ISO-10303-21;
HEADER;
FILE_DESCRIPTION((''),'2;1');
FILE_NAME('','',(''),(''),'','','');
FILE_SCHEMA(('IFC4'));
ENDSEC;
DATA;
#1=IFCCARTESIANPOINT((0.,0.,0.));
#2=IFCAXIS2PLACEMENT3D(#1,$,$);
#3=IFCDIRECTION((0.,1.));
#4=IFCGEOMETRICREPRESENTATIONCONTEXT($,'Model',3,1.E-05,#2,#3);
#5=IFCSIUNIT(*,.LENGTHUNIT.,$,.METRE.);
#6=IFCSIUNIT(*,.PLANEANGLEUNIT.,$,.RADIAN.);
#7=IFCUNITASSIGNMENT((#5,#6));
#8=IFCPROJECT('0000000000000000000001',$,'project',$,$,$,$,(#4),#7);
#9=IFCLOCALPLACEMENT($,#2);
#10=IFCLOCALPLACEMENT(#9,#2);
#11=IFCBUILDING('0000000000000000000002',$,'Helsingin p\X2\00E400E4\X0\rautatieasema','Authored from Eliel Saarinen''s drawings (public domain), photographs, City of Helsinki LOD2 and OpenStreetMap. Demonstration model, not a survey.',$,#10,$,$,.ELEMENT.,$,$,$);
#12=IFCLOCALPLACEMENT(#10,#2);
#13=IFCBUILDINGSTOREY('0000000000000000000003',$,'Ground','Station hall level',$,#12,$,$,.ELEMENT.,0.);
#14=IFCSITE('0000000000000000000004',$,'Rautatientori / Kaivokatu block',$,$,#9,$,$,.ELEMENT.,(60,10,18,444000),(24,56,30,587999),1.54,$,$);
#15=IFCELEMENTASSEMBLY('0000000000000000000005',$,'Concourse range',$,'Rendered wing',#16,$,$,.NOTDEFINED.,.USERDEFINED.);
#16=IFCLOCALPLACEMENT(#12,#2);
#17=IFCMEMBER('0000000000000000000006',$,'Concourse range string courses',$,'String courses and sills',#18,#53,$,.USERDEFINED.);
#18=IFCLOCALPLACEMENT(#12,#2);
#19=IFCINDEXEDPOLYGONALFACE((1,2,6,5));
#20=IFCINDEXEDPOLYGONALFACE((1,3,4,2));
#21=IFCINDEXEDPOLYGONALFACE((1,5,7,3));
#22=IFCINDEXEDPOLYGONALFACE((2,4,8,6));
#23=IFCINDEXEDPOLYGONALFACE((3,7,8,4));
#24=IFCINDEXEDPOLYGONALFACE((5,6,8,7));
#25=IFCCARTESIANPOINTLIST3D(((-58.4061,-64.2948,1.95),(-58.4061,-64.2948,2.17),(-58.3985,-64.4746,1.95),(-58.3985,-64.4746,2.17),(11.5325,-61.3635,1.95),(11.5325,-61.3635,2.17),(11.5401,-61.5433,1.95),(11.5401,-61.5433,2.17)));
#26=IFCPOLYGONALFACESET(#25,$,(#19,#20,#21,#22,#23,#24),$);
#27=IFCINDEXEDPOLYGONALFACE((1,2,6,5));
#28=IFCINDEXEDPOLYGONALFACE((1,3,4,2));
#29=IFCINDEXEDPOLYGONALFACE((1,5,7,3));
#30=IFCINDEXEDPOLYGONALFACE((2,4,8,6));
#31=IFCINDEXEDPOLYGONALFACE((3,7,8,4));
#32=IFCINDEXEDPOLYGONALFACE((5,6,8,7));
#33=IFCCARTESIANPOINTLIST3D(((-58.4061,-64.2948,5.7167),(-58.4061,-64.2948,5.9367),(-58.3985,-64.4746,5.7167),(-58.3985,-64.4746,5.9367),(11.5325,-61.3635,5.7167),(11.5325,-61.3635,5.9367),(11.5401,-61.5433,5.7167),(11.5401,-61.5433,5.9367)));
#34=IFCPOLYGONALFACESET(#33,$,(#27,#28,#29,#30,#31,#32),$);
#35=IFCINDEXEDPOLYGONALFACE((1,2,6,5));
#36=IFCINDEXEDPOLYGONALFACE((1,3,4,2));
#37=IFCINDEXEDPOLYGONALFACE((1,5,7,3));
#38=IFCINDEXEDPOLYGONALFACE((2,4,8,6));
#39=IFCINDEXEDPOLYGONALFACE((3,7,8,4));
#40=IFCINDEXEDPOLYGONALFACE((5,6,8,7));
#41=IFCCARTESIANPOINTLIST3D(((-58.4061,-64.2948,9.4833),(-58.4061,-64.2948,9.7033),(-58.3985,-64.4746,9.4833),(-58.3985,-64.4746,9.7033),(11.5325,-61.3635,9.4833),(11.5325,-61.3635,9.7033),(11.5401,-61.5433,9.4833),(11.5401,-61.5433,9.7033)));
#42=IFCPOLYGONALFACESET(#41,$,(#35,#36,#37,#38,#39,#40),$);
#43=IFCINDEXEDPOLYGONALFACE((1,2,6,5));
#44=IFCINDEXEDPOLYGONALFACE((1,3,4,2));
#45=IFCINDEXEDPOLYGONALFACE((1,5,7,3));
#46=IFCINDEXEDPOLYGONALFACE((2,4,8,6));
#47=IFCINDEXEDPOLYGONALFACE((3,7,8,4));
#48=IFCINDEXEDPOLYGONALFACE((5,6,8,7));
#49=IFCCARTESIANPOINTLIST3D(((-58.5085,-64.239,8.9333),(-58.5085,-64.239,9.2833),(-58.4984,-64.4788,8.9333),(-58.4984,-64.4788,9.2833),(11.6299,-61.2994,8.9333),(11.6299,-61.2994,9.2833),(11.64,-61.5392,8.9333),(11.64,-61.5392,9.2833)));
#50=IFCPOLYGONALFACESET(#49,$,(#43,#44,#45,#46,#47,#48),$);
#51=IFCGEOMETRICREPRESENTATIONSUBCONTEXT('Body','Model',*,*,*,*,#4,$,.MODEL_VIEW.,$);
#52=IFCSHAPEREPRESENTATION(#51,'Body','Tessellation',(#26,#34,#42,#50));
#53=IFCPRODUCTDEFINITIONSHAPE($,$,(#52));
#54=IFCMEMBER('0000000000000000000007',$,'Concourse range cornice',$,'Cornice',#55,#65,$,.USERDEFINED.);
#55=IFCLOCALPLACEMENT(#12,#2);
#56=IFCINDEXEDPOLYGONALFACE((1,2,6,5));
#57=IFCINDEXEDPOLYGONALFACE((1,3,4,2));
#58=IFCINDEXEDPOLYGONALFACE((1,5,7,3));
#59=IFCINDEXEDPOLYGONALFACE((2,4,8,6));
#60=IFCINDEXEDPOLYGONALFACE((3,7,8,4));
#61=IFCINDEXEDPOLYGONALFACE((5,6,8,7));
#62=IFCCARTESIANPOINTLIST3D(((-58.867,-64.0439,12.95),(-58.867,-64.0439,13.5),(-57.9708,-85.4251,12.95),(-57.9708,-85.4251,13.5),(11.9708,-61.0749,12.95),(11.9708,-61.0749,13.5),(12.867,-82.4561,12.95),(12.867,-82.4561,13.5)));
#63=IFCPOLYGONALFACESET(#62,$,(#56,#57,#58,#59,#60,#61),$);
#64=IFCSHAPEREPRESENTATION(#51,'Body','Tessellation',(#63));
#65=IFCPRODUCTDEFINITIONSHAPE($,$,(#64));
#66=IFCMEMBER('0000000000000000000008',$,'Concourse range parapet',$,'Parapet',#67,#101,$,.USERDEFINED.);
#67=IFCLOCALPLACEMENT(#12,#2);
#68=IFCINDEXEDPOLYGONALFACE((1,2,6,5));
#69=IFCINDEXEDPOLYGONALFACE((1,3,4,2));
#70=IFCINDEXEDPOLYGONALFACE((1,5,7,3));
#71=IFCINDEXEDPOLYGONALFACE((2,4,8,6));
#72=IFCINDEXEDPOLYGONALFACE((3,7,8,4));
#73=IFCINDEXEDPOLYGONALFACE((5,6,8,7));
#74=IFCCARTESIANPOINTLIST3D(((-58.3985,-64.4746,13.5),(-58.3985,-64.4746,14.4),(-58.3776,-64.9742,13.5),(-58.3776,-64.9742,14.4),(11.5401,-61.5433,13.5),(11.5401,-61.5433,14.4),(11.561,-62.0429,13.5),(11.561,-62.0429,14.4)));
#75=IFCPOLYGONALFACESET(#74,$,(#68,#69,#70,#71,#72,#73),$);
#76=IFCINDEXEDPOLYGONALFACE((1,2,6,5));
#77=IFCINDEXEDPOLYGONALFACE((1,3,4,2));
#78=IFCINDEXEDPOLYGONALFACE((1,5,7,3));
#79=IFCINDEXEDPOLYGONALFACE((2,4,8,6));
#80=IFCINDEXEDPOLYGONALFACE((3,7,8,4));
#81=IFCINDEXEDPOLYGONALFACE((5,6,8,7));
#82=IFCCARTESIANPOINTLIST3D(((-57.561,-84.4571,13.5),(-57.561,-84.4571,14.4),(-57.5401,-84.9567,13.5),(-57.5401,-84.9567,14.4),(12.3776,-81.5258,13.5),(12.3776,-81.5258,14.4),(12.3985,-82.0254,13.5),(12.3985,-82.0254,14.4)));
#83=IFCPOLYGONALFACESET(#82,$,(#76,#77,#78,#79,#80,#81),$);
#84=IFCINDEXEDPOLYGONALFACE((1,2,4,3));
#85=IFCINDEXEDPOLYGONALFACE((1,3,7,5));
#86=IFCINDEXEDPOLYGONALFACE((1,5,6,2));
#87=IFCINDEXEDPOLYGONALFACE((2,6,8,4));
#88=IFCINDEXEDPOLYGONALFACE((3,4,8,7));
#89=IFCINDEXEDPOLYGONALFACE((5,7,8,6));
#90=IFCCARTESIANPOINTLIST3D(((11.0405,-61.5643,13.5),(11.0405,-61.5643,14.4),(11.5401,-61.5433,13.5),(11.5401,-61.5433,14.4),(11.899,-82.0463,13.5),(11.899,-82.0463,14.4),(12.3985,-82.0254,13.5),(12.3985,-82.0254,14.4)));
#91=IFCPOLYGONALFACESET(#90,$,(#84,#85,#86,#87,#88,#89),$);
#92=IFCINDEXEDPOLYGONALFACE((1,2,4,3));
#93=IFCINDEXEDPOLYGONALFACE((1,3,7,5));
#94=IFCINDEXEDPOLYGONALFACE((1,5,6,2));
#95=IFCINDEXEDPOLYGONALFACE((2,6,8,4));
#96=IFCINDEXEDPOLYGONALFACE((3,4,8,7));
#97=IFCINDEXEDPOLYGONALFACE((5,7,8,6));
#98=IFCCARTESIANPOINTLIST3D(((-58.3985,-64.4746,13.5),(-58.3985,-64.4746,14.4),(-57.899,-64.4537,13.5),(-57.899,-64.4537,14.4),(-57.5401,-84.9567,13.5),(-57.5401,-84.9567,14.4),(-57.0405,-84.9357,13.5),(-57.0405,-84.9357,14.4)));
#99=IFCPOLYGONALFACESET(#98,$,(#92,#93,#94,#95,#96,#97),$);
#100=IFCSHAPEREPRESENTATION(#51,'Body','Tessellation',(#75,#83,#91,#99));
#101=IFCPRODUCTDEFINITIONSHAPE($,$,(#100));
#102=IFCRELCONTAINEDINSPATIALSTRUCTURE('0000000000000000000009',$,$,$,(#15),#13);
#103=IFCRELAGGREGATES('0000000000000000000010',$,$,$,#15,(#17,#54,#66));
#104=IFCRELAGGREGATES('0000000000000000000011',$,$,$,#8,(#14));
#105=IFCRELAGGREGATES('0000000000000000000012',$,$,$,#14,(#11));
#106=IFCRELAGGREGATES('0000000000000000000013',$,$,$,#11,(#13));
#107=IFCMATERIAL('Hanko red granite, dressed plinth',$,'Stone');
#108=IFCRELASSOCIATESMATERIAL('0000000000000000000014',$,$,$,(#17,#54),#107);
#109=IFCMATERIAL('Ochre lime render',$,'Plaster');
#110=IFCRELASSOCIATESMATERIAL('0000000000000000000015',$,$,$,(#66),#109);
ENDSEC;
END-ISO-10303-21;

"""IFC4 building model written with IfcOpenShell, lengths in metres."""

from ifc_helpers import new_model, si_unit, direction, frame, frame_2d, origin, place, context, subcontext, project, spatial, rectangle, extrude, material, element, aggregate, save


model = new_model("IFC4")

# Units and contexts
model_context = context("Model", 3, precision=1e-05, world=origin(), true_north=direction((0.0, 1.0)))
body_context = subcontext(model_context, "Body", "Model", "MODEL_VIEW")
ifc_project = project(units=[si_unit("LENGTHUNIT", "METRE"), si_unit("PLANEANGLEUNIT", "RADIAN")], contexts=[model_context])

# Site, building, storey
site_placement = place(None, origin())
site = spatial("IfcSite", under=ifc_project, at=site_placement, Name="Rautatientori / Kaivokatu block", CompositionType="ELEMENT", RefLatitude=(60, 10, 18, 444000), RefLongitude=(24, 56, 30, 587999), RefElevation=1.54)
building_placement = place(site_placement, origin())
building = spatial("IfcBuilding", under=site, at=building_placement, Name="Helsingin päärautatieasema", Description="Authored from Eliel Saarinen's drawings (public domain), photographs, City of Helsinki LOD2 and OpenStreetMap. Demonstration model, not a survey.", CompositionType="ELEMENT")
storey_placement = place(building_placement, origin())
storey = spatial("IfcBuildingStorey", under=building, at=storey_placement, Name="Ground", Description="Station hall level", CompositionType="ELEMENT", Elevation=0.0)

# Element assembly, members
assembly_1_placement = place(building_placement, origin())
assembly_1 = element("IfcElementAssembly", 1, at=assembly_1_placement, inside=storey, Name="Concourse range", ObjectType="Rendered wing", AssemblyPlace="NOTDEFINED", PredefinedType="USERDEFINED")
ifc_material_1 = material(Name="Hanko red granite, dressed plinth", Category="Stone")
member_1_placement = place(building_placement, origin())
member_1 = element("IfcMember", 2, at=member_1_placement, material=ifc_material_1, Name="Concourse range string courses", ObjectType="String courses and sills", PredefinedType="USERDEFINED", context=body_context, shape_type="SweptSolid", body=[
    extrude(rectangle(XDim=70.0, YDim=0.18, at=frame_2d((0.0, 0.0), x_axis=(-0.999123, -0.041876))), frame((-23.433, -62.9191, 1.95)), (0.0, 0.0, 1.0), 0.22),
    extrude(rectangle(XDim=70.0, YDim=0.18, at=frame_2d((0.0, 0.0), x_axis=(-0.999123, -0.041876))), frame((-23.433, -62.9191, 5.7167)), (0.0, 0.0, 1.0), 0.22),
    extrude(rectangle(XDim=70.0, YDim=0.18, at=frame_2d((0.0, 0.0), x_axis=(-0.999123, -0.041876))), frame((-23.433, -62.9191, 9.4833)), (0.0, 0.0, 1.0), 0.22),
    extrude(rectangle(XDim=70.2, YDim=0.24, at=frame_2d((0.0, 0.0), x_axis=(-0.999123, -0.041876))), frame((-23.4343, -62.8891, 8.9333)), (0.0, 0.0, 1.0), 0.35),
])
member_2_placement = place(building_placement, origin())
member_2 = element("IfcMember", 3, at=member_2_placement, material=ifc_material_1, Name="Concourse range cornice", ObjectType="Cornice", PredefinedType="USERDEFINED", context=body_context, shape_type="SweptSolid", body=[
    extrude(rectangle(XDim=70.9, YDim=21.4, at=frame_2d((0.0, 0.0), x_axis=(0.999123, 0.041876))), frame((-23.0, -73.25, 12.95)), (0.0, 0.0, 1.0), 0.55),
])
ifc_material_2 = material(Name="Ochre lime render", Category="Plaster")
member_3_placement = place(building_placement, origin())
member_3 = element("IfcMember", 4, at=member_3_placement, material=ifc_material_2, Name="Concourse range parapet", ObjectType="Parapet", PredefinedType="USERDEFINED", context=body_context, shape_type="SweptSolid", body=[
    extrude(rectangle(XDim=70.0, YDim=0.5, at=frame_2d((0.0, 0.0), x_axis=(-0.999123, -0.041876))), frame((-23.4188, -63.2588, 13.5)), (0.0, 0.0, 1.0), 0.9),
    extrude(rectangle(XDim=70.0, YDim=0.5, at=frame_2d((0.0, 0.0), x_axis=(0.999123, 0.041876))), frame((-22.5812, -83.2412, 13.5)), (0.0, 0.0, 1.0), 0.9),
    extrude(rectangle(XDim=20.5, YDim=0.5, at=frame_2d((0.0, 0.0), x_axis=(-0.041876, 0.999123))), frame((11.7195, -71.7948, 13.5)), (0.0, 0.0, 1.0), 0.9),
    extrude(rectangle(XDim=20.5, YDim=0.5, at=frame_2d((0.0, 0.0), x_axis=(0.041876, -0.999123))), frame((-57.7195, -74.7052, 13.5)), (0.0, 0.0, 1.0), 0.9),
])

aggregate(assembly_1, [member_1, member_2, member_3])

save(model, "model.ifc")
